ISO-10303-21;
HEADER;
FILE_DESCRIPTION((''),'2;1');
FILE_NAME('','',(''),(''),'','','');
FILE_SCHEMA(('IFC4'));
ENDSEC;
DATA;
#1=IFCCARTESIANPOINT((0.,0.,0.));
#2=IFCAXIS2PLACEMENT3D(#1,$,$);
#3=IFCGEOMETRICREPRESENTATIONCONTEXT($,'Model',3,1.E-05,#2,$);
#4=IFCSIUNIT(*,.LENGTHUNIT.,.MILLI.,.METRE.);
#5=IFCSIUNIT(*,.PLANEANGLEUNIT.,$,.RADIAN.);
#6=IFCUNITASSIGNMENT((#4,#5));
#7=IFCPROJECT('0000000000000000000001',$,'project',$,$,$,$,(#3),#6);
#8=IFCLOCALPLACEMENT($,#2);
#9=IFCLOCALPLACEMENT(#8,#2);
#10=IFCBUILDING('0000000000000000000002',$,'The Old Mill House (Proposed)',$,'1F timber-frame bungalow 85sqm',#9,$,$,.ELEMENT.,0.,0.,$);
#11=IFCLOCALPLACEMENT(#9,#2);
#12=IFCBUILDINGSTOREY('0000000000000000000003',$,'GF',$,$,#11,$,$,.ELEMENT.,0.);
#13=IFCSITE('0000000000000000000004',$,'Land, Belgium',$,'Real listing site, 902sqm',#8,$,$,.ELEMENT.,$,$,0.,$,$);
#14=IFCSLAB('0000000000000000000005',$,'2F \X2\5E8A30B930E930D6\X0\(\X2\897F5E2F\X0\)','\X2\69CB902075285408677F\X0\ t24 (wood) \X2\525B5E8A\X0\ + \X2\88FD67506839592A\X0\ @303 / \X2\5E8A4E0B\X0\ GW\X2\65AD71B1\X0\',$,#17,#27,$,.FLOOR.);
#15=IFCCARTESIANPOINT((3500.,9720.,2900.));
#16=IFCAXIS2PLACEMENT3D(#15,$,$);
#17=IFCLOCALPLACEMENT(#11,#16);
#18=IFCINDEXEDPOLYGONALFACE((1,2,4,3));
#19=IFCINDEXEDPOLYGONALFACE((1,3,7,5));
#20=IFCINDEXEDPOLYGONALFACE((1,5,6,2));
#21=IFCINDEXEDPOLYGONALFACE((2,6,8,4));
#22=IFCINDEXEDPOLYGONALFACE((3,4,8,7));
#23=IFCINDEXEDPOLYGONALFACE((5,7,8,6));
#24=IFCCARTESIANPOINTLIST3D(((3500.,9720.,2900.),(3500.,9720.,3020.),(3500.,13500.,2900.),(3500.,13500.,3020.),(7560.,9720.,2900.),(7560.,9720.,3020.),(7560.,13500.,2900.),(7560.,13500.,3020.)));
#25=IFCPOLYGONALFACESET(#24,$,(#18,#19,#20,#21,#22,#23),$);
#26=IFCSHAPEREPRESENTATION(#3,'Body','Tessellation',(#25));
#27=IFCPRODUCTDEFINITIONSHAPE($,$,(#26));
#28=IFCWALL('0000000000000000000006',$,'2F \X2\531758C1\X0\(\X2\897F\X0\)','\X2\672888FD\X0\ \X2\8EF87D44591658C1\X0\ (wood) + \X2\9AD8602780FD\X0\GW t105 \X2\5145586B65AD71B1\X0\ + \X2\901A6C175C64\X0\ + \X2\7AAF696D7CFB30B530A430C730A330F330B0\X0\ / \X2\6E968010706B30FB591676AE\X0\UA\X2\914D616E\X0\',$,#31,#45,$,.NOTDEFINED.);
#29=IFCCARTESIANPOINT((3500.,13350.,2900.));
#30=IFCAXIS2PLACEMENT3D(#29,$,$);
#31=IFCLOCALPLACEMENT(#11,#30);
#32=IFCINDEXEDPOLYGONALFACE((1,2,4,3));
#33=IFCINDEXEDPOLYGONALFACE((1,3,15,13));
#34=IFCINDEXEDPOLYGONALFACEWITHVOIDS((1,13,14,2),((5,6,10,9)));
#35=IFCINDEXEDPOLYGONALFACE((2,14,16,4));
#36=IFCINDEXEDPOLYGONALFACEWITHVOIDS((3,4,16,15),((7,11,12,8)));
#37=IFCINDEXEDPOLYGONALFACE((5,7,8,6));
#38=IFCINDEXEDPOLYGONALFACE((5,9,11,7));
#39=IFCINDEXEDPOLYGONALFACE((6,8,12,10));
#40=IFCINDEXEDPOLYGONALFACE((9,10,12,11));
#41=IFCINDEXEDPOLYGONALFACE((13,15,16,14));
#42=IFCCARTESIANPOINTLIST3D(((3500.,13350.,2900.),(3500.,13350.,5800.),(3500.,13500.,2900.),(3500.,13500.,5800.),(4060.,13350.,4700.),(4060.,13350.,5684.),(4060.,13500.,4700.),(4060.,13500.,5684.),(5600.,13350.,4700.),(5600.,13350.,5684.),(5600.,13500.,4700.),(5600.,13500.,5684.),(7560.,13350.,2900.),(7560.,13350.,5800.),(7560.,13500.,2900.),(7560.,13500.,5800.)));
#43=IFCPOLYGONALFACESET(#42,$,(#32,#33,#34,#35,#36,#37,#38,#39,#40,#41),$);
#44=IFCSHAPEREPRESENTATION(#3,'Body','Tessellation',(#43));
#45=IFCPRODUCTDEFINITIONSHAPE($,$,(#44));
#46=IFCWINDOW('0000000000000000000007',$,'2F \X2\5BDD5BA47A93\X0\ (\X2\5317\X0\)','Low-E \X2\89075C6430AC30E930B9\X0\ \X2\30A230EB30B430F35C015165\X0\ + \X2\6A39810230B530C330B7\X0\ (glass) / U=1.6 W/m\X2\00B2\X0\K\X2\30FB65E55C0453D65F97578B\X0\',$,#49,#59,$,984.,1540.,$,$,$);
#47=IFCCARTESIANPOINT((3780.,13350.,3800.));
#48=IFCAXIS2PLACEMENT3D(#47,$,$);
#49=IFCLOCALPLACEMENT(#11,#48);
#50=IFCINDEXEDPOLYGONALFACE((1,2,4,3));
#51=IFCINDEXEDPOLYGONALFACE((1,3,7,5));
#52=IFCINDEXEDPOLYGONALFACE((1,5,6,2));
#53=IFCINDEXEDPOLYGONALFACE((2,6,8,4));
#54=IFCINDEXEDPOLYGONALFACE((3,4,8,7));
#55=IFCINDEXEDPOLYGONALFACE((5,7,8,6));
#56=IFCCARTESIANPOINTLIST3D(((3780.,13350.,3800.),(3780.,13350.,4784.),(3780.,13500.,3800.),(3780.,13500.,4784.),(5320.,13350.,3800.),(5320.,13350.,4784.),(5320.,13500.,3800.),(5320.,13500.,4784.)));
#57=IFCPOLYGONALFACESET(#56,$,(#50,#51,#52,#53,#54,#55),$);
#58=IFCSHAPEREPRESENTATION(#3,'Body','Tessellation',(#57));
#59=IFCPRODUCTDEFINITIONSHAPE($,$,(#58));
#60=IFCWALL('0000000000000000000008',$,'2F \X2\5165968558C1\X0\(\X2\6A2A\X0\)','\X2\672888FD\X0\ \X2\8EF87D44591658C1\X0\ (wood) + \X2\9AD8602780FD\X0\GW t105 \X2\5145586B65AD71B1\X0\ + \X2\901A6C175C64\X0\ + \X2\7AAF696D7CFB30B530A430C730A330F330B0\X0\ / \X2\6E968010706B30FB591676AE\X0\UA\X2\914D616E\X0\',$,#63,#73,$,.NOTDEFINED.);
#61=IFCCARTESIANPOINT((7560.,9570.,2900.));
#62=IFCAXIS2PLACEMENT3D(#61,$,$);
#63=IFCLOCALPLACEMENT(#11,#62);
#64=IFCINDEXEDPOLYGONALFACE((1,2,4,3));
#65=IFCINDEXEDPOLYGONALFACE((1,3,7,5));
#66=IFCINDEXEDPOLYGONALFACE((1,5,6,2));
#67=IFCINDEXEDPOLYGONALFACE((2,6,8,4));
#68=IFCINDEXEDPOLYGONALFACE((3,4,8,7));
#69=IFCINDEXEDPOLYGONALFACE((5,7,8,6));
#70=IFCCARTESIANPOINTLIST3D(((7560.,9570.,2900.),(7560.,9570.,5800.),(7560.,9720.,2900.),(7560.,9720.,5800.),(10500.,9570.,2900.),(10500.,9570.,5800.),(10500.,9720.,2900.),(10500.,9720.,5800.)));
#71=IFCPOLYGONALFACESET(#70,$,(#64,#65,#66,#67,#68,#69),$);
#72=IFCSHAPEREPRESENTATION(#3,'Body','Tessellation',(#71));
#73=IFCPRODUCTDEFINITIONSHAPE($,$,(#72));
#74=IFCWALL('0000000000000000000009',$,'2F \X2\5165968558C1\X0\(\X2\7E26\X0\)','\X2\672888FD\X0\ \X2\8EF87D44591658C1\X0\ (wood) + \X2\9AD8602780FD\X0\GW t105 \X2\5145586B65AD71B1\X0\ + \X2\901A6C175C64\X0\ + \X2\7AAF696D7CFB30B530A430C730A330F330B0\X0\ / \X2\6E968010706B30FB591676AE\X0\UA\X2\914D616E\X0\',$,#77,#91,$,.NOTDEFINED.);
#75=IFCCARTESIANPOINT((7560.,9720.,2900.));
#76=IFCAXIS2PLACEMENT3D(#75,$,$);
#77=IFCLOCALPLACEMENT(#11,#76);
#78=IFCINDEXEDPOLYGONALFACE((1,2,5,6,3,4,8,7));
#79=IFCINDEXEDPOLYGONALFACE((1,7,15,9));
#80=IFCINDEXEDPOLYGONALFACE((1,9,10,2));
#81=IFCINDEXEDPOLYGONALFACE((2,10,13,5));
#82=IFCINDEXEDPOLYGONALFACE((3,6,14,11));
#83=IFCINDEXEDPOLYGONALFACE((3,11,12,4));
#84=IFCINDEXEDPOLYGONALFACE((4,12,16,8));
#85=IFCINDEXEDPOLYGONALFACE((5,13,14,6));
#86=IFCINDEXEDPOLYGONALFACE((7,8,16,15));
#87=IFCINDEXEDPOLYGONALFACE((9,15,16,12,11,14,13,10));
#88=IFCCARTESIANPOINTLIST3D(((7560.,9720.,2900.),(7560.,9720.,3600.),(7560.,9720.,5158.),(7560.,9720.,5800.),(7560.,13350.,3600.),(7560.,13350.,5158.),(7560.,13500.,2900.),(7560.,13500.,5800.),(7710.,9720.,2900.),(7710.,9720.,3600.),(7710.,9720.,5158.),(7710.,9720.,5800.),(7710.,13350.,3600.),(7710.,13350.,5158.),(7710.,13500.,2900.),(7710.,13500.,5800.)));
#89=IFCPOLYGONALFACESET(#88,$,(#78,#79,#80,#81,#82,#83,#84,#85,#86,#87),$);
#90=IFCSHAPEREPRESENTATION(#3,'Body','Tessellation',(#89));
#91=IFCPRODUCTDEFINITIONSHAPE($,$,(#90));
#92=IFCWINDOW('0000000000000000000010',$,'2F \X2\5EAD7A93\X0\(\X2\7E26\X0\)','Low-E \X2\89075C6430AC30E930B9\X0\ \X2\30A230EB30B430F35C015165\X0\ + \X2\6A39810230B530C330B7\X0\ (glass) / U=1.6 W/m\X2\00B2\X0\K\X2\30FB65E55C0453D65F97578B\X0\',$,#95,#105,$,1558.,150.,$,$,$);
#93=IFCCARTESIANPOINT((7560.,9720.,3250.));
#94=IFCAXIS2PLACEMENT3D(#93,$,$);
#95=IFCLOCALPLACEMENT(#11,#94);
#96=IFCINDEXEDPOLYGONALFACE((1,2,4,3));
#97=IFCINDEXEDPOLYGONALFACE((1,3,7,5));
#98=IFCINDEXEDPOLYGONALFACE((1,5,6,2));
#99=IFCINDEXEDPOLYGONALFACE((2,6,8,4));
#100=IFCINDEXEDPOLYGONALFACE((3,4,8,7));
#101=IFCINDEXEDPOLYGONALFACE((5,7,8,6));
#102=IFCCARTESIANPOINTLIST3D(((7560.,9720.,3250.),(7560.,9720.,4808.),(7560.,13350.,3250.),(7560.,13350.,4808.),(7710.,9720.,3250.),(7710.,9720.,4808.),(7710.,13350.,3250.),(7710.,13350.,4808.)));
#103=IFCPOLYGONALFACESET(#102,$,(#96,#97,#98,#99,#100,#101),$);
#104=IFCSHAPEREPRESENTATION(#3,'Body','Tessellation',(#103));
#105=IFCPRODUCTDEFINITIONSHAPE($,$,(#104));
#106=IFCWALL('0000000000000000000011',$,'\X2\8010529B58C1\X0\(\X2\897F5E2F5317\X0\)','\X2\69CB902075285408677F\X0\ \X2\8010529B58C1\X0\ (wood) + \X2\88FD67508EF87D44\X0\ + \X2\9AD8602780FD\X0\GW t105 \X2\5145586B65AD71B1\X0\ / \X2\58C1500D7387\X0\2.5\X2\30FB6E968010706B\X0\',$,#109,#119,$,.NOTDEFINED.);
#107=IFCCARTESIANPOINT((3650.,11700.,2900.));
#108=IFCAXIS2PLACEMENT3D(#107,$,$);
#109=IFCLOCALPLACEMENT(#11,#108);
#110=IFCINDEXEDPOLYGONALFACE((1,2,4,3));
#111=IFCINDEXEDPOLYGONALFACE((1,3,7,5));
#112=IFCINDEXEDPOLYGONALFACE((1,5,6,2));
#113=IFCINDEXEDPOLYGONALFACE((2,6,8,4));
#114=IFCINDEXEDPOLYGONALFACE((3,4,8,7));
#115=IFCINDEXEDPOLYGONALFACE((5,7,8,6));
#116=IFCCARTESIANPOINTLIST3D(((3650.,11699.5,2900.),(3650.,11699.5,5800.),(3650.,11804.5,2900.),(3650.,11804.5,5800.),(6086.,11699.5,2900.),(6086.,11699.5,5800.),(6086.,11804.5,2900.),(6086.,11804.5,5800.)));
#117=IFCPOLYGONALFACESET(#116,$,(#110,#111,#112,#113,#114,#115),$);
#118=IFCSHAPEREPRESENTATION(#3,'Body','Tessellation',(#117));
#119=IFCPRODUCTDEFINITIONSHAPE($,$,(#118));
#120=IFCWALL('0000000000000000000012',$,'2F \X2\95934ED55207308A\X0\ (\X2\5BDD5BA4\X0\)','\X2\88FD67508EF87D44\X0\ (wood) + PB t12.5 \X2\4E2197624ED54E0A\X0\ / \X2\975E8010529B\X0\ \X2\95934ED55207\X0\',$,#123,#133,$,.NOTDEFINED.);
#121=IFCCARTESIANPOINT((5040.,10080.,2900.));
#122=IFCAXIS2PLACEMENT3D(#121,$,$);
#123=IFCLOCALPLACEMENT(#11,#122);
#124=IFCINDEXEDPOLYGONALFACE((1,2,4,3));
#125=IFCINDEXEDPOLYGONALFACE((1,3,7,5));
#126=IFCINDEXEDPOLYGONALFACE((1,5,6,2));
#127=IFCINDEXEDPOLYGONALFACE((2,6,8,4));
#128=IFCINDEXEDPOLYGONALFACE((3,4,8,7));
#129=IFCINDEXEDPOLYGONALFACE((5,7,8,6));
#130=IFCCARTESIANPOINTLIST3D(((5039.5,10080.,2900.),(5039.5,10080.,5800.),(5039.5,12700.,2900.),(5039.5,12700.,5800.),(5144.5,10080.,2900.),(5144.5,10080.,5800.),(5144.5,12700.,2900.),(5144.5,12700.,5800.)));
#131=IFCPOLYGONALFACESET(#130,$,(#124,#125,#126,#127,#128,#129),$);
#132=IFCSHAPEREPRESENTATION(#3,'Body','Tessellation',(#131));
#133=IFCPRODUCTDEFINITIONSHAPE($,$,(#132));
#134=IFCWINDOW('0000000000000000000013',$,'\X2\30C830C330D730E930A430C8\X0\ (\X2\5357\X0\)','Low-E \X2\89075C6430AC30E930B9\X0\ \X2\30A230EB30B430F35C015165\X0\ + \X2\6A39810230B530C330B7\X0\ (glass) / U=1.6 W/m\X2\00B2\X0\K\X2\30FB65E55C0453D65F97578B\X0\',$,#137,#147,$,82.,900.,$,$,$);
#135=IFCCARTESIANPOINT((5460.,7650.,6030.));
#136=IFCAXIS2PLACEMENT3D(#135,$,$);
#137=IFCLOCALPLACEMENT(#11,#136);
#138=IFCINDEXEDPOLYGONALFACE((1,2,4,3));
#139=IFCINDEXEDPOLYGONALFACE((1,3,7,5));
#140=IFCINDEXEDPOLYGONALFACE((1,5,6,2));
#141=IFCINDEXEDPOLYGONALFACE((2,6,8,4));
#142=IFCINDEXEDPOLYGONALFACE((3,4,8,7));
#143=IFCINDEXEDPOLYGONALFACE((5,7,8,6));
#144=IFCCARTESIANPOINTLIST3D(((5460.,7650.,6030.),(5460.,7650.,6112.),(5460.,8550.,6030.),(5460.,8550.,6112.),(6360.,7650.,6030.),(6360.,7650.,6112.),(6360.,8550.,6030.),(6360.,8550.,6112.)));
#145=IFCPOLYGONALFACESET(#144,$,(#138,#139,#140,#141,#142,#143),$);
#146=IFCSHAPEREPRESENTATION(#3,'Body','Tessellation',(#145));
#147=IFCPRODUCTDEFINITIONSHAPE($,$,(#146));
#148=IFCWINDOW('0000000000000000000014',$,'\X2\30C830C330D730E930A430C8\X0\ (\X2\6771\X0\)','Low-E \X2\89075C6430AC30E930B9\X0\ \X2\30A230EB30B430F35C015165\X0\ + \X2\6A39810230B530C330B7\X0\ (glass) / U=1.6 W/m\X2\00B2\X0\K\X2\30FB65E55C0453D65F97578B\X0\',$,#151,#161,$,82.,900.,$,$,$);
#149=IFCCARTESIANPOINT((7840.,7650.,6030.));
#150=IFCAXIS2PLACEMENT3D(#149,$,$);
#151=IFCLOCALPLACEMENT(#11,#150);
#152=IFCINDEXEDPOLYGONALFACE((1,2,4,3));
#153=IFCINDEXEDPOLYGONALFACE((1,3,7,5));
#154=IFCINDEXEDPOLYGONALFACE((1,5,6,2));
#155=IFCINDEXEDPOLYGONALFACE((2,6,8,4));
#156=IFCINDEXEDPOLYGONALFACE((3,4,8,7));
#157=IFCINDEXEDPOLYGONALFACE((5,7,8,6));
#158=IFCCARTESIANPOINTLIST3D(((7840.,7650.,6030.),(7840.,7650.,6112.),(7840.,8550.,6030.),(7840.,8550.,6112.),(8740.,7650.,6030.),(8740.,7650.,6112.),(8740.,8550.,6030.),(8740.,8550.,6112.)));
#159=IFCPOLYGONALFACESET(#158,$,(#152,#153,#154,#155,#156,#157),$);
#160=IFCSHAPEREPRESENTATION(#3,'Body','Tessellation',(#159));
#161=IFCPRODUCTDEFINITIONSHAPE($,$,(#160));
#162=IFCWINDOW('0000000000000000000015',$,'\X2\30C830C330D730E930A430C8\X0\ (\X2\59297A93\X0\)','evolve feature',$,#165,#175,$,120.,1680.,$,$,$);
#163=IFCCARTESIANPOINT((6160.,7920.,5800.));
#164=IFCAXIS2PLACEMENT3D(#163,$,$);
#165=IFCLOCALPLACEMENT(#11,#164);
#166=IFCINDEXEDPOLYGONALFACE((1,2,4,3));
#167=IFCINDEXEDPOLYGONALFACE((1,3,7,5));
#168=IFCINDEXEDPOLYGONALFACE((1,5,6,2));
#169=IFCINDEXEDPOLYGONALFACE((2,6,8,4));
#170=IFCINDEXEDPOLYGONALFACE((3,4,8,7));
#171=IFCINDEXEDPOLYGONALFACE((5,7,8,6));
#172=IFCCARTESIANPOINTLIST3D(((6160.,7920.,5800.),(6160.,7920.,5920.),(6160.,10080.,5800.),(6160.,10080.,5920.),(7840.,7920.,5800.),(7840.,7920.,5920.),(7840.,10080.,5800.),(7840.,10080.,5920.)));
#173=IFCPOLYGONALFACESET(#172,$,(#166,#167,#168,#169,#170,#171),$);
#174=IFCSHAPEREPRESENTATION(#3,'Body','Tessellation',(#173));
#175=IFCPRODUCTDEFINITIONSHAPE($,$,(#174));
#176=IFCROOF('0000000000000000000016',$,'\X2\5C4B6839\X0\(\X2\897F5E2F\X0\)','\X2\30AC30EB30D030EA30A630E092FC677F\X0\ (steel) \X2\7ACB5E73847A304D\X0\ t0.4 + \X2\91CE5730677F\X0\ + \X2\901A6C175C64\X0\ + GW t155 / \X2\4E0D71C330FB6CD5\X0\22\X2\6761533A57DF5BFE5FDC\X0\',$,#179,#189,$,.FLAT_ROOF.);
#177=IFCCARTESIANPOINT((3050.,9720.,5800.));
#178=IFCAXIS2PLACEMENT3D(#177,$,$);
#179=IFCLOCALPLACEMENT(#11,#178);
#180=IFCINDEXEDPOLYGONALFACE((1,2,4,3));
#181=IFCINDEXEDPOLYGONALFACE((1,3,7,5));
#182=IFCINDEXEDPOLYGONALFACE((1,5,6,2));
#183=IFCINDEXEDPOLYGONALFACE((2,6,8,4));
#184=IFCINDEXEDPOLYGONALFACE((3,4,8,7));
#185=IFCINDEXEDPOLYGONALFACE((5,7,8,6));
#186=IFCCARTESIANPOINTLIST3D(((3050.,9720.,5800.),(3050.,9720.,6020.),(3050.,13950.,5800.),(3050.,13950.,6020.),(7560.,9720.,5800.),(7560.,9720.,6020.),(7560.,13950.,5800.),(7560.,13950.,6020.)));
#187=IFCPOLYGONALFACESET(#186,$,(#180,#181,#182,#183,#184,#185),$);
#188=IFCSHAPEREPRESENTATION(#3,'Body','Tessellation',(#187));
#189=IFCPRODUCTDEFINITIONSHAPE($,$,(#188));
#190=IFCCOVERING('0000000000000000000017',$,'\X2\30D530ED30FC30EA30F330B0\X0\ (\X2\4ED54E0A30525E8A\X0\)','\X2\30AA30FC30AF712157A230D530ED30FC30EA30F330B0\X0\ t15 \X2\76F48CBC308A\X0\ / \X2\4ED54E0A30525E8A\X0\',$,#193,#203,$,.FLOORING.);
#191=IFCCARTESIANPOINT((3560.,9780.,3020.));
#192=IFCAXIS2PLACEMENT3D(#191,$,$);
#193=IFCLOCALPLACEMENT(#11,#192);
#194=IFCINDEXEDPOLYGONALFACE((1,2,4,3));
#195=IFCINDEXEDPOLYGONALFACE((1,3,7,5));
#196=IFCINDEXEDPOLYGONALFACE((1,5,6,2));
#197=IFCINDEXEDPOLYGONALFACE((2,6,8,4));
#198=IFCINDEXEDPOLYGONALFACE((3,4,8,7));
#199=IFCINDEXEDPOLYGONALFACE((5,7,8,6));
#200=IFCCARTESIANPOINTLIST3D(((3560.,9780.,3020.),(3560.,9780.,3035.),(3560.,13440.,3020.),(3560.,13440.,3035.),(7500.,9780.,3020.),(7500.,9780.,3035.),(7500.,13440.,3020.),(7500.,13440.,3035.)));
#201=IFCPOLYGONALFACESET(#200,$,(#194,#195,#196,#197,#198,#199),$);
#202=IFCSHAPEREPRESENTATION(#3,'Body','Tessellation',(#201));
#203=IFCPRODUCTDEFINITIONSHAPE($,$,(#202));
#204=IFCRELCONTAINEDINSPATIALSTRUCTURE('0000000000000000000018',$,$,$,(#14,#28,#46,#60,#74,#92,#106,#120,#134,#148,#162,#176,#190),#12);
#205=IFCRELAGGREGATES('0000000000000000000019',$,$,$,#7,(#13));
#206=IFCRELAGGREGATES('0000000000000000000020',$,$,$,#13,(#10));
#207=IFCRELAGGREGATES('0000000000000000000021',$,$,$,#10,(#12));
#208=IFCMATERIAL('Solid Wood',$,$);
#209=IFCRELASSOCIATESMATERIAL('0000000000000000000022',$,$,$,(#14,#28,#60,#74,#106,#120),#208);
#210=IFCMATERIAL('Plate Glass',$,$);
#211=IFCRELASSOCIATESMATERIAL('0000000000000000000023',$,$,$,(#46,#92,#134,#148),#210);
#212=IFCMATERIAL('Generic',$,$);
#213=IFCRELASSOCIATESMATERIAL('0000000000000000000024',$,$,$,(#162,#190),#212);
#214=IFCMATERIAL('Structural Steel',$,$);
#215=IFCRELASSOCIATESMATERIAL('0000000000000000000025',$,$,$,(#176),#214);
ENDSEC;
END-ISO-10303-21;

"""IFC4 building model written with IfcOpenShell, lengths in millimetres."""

from ifc_helpers import new_model, si_unit, frame, frame_2d, origin, place, context, project, spatial, rectangle, extrude, material, element, fill, save


model = new_model("IFC4")

# Units and contexts
model_context = context("Model", 3, precision=1e-05, world=origin())
ifc_project = project(units=[si_unit("LENGTHUNIT", "METRE", prefix="MILLI"), si_unit("PLANEANGLEUNIT", "RADIAN")], contexts=[model_context])

# Site, building, storey
site_placement = place(None, origin())
site = spatial("IfcSite", under=ifc_project, at=site_placement, Name="Land, Belgium", ObjectType="Real listing site, 902sqm", CompositionType="ELEMENT", RefElevation=0.0)
building_placement = place(site_placement, origin())
building = spatial("IfcBuilding", under=site, at=building_placement, Name="The Old Mill House (Proposed)", ObjectType="1F timber-frame bungalow 85sqm", CompositionType="ELEMENT", ElevationOfRefHeight=0.0, ElevationOfTerrain=0.0)
storey_placement = place(building_placement, origin())
storey = spatial("IfcBuildingStorey", under=building, at=storey_placement, Name="GF", CompositionType="ELEMENT", Elevation=0.0)

# Slab
ifc_material_1 = material(Name="Solid Wood")
slab_placement = place(storey_placement, frame((3500.0, 9720.0, 2900.0)))
element("IfcSlab", 1, at=slab_placement, inside=storey, material=ifc_material_1, Name="2F 床スラブ(西帯)", Description="構造用合板 t24 (wood) 剛床 + 製材根太 @303 / 床下 GW断熱", PredefinedType="FLOOR", context=model_context, shape_type="SweptSolid", body=[
    extrude(rectangle(XDim=4060.0, YDim=3780.0, at=frame_2d((2030.0, 1890.0))), frame((3500.0, 9720.0, 2900.0)), (0.0, 0.0, 1.0), 120.0),
])

# Wall, opening, window
wall_1_placement = place(storey_placement, frame((3500.0, 13350.0, 2900.0)))
wall_1 = element("IfcWall", 2, at=wall_1_placement, inside=storey, material=ifc_material_1, Name="2F 北壁(西)", Description="木製 軸組外壁 (wood) + 高性能GW t105 充填断熱 + 通気層 + 窯業系サイディング / 準耐火・外皮UA配慮", PredefinedType="NOTDEFINED", context=model_context, shape_type="SweptSolid", body=[
    extrude(rectangle(XDim=4060.0, YDim=150.0, at=frame_2d((2030.0, 75.0))), frame((3500.0, 13350.0, 2900.0)), (0.0, 0.0, 1.0), 2900.0),
])
opening_1_placement = place(storey_placement, frame((3780.0, 13350.0, 3800.0)))
opening_1 = element("IfcOpeningElement", 3, at=opening_1_placement, cuts=wall_1, PredefinedType="NOTDEFINED", context=model_context, shape_type="SweptSolid", body=[
    extrude(rectangle(XDim=1540.0, YDim=150.0, at=frame_2d((770.0, 75.0))), frame((3780.0, 13350.0, 3800.0)), (0.0, 0.0, 1.0), 984.0),
])
ifc_material_2 = material(Name="Plate Glass")
window_1_placement = place(storey_placement, frame((3780.0, 13350.0, 3800.0)))
window_1 = element("IfcWindow", 4, at=window_1_placement, inside=storey, material=ifc_material_2, Name="2F 寝室窓 (北)", Description="Low-E 複層ガラス アルゴン封入 + 樹脂サッシ (glass) / U=1.6 W/m²K・日射取得型", OverallHeight=984.0, OverallWidth=1540.0, context=model_context, shape_type="SweptSolid", body=[
    extrude(rectangle(XDim=1540.0, YDim=150.0, at=frame_2d((770.0, 75.0))), frame((3780.0, 13350.0, 3800.0)), (0.0, 0.0, 1.0), 984.0),
])
fill(opening_1, window_1)

# Wall
wall_2_placement = place(storey_placement, frame((7560.0, 9570.0, 2900.0)))
element("IfcWall", 5, at=wall_2_placement, inside=storey, material=ifc_material_1, Name="2F 入隅壁(横)", Description="木製 軸組外壁 (wood) + 高性能GW t105 充填断熱 + 通気層 + 窯業系サイディング / 準耐火・外皮UA配慮", PredefinedType="NOTDEFINED", context=model_context, shape_type="SweptSolid", body=[
    extrude(rectangle(XDim=2940.0, YDim=150.0, at=frame_2d((1470.0, 75.0))), frame((7560.0, 9570.0, 2900.0)), (0.0, 0.0, 1.0), 2900.0),
])

# Wall, opening, window
wall_3_placement = place(storey_placement, frame((7560.0, 9720.0, 2900.0)))
wall_3 = element("IfcWall", 6, at=wall_3_placement, inside=storey, material=ifc_material_1, Name="2F 入隅壁(縦)", Description="木製 軸組外壁 (wood) + 高性能GW t105 充填断熱 + 通気層 + 窯業系サイディング / 準耐火・外皮UA配慮", PredefinedType="NOTDEFINED", context=model_context, shape_type="SweptSolid", body=[
    extrude(rectangle(XDim=150.0, YDim=3780.0, at=frame_2d((75.0, 1890.0))), frame((7560.0, 9720.0, 2900.0)), (0.0, 0.0, 1.0), 2900.0),
])
opening_2_placement = place(storey_placement, frame((7560.0, 9720.0, 3250.0)))
opening_2 = element("IfcOpeningElement", 7, at=opening_2_placement, cuts=wall_3, PredefinedType="NOTDEFINED", context=model_context, shape_type="SweptSolid", body=[
    extrude(rectangle(XDim=150.0, YDim=3630.0, at=frame_2d((75.0, 1815.0))), frame((7560.0, 9720.0, 3250.0)), (0.0, 0.0, 1.0), 1558.0),
])
window_2_placement = place(storey_placement, frame((7560.0, 9720.0, 3250.0)))
window_2 = element("IfcWindow", 8, at=window_2_placement, inside=storey, material=ifc_material_2, Name="2F 庭窓(縦)", Description="Low-E 複層ガラス アルゴン封入 + 樹脂サッシ (glass) / U=1.6 W/m²K・日射取得型", OverallHeight=1558.0, OverallWidth=150.0, context=model_context, shape_type="SweptSolid", body=[
    extrude(rectangle(XDim=150.0, YDim=3630.0, at=frame_2d((75.0, 1815.0))), frame((7560.0, 9720.0, 3250.0)), (0.0, 0.0, 1.0), 1558.0),
])
fill(opening_2, window_2)

# Walls
wall_4_placement = place(storey_placement, frame((3650.0, 11700.0, 2900.0)))
element("IfcWall", 9, at=wall_4_placement, inside=storey, material=ifc_material_1, Name="耐力壁(西帯北)", Description="構造用合板 耐力壁 (wood) + 製材軸組 + 高性能GW t105 充填断熱 / 壁倍率2.5・準耐火", PredefinedType="NOTDEFINED", context=model_context, shape_type="SweptSolid", body=[
    extrude(rectangle(XDim=2436.0, YDim=105.0, at=frame_2d((1218.0, 52.0))), frame((3650.0, 11700.0, 2900.0)), (0.0, 0.0, 1.0), 2900.0),
])
wall_5_placement = place(storey_placement, frame((5040.0, 10080.0, 2900.0)))
element("IfcWall", 10, at=wall_5_placement, inside=storey, material=ifc_material_1, Name="2F 間仕切り (寝室)", Description="製材軸組 (wood) + PB t12.5 両面仕上 / 非耐力 間仕切", PredefinedType="NOTDEFINED", context=model_context, shape_type="SweptSolid", body=[
    extrude(rectangle(XDim=105.0, YDim=2620.0, at=frame_2d((52.0, 1310.0))), frame((5040.0, 10080.0, 2900.0)), (0.0, 0.0, 1.0), 2900.0),
])

# Windows
window_3_placement = place(storey_placement, frame((5460.0, 7650.0, 6030.0)))
element("IfcWindow", 11, at=window_3_placement, inside=storey, material=ifc_material_2, Name="トップライト (南)", Description="Low-E 複層ガラス アルゴン封入 + 樹脂サッシ (glass) / U=1.6 W/m²K・日射取得型", OverallHeight=82.0, OverallWidth=900.0, context=model_context, shape_type="SweptSolid", body=[
    extrude(rectangle(XDim=900.0, YDim=900.0, at=frame_2d((450.0, 450.0))), frame((5460.0, 7650.0, 6030.0)), (0.0, 0.0, 1.0), 82.0),
])
window_4_placement = place(storey_placement, frame((7840.0, 7650.0, 6030.0)))
element("IfcWindow", 12, at=window_4_placement, inside=storey, material=ifc_material_2, Name="トップライト (東)", Description="Low-E 複層ガラス アルゴン封入 + 樹脂サッシ (glass) / U=1.6 W/m²K・日射取得型", OverallHeight=82.0, OverallWidth=900.0, context=model_context, shape_type="SweptSolid", body=[
    extrude(rectangle(XDim=900.0, YDim=900.0, at=frame_2d((450.0, 450.0))), frame((7840.0, 7650.0, 6030.0)), (0.0, 0.0, 1.0), 82.0),
])
ifc_material_3 = material(Name="Generic")
window_5_placement = place(storey_placement, frame((6160.0, 7920.0, 5800.0)))
element("IfcWindow", 13, at=window_5_placement, inside=storey, material=ifc_material_3, Name="トップライト (天窓)", Description="evolve feature", OverallHeight=120.0, OverallWidth=1680.0, context=model_context, shape_type="SweptSolid", body=[
    extrude(rectangle(XDim=1680.0, YDim=2160.0, at=frame_2d((840.0, 1080.0))), frame((6160.0, 7920.0, 5800.0)), (0.0, 0.0, 1.0), 120.0),
])

# Roof
ifc_material_4 = material(Name="Structural Steel")
for number, where, name in (
    (14, (3050.0, 9720.0, 5800.0), "屋根(西帯)"),
):
    element("IfcRoof", number, at=place(storey_placement, frame(where)), inside=storey, material=ifc_material_4, Name=name, Description="ガルバリウム鋼板 (steel) 立平葺き t0.4 + 野地板 + 通気層 + GW t155 / 不燃・法22条区域対応", PredefinedType="FLAT_ROOF", context=model_context, shape_type="SweptSolid", body=[
        extrude(rectangle(XDim=4510.0, YDim=4230.0, at=frame_2d((2255.0, 2115.0))), frame((3050.0, 9720.0, 5800.0)), (0.0, 0.0, 1.0), 220.0),
    ])

# Covering
covering_placement = place(storey_placement, frame((3560.0, 9780.0, 3020.0)))
element("IfcCovering", 15, at=covering_placement, inside=storey, material=ifc_material_3, Name="フローリング (仕上げ床)", Description="オーク無垢フローリング t15 直貼り / 仕上げ床", PredefinedType="FLOORING", context=model_context, shape_type="SweptSolid", body=[
    extrude(rectangle(XDim=3940.0, YDim=3660.0, at=frame_2d((1970.0, 1830.0))), frame((3560.0, 9780.0, 3020.0)), (0.0, 0.0, 1.0), 15.0),
])

save(model, "model.ifc")
